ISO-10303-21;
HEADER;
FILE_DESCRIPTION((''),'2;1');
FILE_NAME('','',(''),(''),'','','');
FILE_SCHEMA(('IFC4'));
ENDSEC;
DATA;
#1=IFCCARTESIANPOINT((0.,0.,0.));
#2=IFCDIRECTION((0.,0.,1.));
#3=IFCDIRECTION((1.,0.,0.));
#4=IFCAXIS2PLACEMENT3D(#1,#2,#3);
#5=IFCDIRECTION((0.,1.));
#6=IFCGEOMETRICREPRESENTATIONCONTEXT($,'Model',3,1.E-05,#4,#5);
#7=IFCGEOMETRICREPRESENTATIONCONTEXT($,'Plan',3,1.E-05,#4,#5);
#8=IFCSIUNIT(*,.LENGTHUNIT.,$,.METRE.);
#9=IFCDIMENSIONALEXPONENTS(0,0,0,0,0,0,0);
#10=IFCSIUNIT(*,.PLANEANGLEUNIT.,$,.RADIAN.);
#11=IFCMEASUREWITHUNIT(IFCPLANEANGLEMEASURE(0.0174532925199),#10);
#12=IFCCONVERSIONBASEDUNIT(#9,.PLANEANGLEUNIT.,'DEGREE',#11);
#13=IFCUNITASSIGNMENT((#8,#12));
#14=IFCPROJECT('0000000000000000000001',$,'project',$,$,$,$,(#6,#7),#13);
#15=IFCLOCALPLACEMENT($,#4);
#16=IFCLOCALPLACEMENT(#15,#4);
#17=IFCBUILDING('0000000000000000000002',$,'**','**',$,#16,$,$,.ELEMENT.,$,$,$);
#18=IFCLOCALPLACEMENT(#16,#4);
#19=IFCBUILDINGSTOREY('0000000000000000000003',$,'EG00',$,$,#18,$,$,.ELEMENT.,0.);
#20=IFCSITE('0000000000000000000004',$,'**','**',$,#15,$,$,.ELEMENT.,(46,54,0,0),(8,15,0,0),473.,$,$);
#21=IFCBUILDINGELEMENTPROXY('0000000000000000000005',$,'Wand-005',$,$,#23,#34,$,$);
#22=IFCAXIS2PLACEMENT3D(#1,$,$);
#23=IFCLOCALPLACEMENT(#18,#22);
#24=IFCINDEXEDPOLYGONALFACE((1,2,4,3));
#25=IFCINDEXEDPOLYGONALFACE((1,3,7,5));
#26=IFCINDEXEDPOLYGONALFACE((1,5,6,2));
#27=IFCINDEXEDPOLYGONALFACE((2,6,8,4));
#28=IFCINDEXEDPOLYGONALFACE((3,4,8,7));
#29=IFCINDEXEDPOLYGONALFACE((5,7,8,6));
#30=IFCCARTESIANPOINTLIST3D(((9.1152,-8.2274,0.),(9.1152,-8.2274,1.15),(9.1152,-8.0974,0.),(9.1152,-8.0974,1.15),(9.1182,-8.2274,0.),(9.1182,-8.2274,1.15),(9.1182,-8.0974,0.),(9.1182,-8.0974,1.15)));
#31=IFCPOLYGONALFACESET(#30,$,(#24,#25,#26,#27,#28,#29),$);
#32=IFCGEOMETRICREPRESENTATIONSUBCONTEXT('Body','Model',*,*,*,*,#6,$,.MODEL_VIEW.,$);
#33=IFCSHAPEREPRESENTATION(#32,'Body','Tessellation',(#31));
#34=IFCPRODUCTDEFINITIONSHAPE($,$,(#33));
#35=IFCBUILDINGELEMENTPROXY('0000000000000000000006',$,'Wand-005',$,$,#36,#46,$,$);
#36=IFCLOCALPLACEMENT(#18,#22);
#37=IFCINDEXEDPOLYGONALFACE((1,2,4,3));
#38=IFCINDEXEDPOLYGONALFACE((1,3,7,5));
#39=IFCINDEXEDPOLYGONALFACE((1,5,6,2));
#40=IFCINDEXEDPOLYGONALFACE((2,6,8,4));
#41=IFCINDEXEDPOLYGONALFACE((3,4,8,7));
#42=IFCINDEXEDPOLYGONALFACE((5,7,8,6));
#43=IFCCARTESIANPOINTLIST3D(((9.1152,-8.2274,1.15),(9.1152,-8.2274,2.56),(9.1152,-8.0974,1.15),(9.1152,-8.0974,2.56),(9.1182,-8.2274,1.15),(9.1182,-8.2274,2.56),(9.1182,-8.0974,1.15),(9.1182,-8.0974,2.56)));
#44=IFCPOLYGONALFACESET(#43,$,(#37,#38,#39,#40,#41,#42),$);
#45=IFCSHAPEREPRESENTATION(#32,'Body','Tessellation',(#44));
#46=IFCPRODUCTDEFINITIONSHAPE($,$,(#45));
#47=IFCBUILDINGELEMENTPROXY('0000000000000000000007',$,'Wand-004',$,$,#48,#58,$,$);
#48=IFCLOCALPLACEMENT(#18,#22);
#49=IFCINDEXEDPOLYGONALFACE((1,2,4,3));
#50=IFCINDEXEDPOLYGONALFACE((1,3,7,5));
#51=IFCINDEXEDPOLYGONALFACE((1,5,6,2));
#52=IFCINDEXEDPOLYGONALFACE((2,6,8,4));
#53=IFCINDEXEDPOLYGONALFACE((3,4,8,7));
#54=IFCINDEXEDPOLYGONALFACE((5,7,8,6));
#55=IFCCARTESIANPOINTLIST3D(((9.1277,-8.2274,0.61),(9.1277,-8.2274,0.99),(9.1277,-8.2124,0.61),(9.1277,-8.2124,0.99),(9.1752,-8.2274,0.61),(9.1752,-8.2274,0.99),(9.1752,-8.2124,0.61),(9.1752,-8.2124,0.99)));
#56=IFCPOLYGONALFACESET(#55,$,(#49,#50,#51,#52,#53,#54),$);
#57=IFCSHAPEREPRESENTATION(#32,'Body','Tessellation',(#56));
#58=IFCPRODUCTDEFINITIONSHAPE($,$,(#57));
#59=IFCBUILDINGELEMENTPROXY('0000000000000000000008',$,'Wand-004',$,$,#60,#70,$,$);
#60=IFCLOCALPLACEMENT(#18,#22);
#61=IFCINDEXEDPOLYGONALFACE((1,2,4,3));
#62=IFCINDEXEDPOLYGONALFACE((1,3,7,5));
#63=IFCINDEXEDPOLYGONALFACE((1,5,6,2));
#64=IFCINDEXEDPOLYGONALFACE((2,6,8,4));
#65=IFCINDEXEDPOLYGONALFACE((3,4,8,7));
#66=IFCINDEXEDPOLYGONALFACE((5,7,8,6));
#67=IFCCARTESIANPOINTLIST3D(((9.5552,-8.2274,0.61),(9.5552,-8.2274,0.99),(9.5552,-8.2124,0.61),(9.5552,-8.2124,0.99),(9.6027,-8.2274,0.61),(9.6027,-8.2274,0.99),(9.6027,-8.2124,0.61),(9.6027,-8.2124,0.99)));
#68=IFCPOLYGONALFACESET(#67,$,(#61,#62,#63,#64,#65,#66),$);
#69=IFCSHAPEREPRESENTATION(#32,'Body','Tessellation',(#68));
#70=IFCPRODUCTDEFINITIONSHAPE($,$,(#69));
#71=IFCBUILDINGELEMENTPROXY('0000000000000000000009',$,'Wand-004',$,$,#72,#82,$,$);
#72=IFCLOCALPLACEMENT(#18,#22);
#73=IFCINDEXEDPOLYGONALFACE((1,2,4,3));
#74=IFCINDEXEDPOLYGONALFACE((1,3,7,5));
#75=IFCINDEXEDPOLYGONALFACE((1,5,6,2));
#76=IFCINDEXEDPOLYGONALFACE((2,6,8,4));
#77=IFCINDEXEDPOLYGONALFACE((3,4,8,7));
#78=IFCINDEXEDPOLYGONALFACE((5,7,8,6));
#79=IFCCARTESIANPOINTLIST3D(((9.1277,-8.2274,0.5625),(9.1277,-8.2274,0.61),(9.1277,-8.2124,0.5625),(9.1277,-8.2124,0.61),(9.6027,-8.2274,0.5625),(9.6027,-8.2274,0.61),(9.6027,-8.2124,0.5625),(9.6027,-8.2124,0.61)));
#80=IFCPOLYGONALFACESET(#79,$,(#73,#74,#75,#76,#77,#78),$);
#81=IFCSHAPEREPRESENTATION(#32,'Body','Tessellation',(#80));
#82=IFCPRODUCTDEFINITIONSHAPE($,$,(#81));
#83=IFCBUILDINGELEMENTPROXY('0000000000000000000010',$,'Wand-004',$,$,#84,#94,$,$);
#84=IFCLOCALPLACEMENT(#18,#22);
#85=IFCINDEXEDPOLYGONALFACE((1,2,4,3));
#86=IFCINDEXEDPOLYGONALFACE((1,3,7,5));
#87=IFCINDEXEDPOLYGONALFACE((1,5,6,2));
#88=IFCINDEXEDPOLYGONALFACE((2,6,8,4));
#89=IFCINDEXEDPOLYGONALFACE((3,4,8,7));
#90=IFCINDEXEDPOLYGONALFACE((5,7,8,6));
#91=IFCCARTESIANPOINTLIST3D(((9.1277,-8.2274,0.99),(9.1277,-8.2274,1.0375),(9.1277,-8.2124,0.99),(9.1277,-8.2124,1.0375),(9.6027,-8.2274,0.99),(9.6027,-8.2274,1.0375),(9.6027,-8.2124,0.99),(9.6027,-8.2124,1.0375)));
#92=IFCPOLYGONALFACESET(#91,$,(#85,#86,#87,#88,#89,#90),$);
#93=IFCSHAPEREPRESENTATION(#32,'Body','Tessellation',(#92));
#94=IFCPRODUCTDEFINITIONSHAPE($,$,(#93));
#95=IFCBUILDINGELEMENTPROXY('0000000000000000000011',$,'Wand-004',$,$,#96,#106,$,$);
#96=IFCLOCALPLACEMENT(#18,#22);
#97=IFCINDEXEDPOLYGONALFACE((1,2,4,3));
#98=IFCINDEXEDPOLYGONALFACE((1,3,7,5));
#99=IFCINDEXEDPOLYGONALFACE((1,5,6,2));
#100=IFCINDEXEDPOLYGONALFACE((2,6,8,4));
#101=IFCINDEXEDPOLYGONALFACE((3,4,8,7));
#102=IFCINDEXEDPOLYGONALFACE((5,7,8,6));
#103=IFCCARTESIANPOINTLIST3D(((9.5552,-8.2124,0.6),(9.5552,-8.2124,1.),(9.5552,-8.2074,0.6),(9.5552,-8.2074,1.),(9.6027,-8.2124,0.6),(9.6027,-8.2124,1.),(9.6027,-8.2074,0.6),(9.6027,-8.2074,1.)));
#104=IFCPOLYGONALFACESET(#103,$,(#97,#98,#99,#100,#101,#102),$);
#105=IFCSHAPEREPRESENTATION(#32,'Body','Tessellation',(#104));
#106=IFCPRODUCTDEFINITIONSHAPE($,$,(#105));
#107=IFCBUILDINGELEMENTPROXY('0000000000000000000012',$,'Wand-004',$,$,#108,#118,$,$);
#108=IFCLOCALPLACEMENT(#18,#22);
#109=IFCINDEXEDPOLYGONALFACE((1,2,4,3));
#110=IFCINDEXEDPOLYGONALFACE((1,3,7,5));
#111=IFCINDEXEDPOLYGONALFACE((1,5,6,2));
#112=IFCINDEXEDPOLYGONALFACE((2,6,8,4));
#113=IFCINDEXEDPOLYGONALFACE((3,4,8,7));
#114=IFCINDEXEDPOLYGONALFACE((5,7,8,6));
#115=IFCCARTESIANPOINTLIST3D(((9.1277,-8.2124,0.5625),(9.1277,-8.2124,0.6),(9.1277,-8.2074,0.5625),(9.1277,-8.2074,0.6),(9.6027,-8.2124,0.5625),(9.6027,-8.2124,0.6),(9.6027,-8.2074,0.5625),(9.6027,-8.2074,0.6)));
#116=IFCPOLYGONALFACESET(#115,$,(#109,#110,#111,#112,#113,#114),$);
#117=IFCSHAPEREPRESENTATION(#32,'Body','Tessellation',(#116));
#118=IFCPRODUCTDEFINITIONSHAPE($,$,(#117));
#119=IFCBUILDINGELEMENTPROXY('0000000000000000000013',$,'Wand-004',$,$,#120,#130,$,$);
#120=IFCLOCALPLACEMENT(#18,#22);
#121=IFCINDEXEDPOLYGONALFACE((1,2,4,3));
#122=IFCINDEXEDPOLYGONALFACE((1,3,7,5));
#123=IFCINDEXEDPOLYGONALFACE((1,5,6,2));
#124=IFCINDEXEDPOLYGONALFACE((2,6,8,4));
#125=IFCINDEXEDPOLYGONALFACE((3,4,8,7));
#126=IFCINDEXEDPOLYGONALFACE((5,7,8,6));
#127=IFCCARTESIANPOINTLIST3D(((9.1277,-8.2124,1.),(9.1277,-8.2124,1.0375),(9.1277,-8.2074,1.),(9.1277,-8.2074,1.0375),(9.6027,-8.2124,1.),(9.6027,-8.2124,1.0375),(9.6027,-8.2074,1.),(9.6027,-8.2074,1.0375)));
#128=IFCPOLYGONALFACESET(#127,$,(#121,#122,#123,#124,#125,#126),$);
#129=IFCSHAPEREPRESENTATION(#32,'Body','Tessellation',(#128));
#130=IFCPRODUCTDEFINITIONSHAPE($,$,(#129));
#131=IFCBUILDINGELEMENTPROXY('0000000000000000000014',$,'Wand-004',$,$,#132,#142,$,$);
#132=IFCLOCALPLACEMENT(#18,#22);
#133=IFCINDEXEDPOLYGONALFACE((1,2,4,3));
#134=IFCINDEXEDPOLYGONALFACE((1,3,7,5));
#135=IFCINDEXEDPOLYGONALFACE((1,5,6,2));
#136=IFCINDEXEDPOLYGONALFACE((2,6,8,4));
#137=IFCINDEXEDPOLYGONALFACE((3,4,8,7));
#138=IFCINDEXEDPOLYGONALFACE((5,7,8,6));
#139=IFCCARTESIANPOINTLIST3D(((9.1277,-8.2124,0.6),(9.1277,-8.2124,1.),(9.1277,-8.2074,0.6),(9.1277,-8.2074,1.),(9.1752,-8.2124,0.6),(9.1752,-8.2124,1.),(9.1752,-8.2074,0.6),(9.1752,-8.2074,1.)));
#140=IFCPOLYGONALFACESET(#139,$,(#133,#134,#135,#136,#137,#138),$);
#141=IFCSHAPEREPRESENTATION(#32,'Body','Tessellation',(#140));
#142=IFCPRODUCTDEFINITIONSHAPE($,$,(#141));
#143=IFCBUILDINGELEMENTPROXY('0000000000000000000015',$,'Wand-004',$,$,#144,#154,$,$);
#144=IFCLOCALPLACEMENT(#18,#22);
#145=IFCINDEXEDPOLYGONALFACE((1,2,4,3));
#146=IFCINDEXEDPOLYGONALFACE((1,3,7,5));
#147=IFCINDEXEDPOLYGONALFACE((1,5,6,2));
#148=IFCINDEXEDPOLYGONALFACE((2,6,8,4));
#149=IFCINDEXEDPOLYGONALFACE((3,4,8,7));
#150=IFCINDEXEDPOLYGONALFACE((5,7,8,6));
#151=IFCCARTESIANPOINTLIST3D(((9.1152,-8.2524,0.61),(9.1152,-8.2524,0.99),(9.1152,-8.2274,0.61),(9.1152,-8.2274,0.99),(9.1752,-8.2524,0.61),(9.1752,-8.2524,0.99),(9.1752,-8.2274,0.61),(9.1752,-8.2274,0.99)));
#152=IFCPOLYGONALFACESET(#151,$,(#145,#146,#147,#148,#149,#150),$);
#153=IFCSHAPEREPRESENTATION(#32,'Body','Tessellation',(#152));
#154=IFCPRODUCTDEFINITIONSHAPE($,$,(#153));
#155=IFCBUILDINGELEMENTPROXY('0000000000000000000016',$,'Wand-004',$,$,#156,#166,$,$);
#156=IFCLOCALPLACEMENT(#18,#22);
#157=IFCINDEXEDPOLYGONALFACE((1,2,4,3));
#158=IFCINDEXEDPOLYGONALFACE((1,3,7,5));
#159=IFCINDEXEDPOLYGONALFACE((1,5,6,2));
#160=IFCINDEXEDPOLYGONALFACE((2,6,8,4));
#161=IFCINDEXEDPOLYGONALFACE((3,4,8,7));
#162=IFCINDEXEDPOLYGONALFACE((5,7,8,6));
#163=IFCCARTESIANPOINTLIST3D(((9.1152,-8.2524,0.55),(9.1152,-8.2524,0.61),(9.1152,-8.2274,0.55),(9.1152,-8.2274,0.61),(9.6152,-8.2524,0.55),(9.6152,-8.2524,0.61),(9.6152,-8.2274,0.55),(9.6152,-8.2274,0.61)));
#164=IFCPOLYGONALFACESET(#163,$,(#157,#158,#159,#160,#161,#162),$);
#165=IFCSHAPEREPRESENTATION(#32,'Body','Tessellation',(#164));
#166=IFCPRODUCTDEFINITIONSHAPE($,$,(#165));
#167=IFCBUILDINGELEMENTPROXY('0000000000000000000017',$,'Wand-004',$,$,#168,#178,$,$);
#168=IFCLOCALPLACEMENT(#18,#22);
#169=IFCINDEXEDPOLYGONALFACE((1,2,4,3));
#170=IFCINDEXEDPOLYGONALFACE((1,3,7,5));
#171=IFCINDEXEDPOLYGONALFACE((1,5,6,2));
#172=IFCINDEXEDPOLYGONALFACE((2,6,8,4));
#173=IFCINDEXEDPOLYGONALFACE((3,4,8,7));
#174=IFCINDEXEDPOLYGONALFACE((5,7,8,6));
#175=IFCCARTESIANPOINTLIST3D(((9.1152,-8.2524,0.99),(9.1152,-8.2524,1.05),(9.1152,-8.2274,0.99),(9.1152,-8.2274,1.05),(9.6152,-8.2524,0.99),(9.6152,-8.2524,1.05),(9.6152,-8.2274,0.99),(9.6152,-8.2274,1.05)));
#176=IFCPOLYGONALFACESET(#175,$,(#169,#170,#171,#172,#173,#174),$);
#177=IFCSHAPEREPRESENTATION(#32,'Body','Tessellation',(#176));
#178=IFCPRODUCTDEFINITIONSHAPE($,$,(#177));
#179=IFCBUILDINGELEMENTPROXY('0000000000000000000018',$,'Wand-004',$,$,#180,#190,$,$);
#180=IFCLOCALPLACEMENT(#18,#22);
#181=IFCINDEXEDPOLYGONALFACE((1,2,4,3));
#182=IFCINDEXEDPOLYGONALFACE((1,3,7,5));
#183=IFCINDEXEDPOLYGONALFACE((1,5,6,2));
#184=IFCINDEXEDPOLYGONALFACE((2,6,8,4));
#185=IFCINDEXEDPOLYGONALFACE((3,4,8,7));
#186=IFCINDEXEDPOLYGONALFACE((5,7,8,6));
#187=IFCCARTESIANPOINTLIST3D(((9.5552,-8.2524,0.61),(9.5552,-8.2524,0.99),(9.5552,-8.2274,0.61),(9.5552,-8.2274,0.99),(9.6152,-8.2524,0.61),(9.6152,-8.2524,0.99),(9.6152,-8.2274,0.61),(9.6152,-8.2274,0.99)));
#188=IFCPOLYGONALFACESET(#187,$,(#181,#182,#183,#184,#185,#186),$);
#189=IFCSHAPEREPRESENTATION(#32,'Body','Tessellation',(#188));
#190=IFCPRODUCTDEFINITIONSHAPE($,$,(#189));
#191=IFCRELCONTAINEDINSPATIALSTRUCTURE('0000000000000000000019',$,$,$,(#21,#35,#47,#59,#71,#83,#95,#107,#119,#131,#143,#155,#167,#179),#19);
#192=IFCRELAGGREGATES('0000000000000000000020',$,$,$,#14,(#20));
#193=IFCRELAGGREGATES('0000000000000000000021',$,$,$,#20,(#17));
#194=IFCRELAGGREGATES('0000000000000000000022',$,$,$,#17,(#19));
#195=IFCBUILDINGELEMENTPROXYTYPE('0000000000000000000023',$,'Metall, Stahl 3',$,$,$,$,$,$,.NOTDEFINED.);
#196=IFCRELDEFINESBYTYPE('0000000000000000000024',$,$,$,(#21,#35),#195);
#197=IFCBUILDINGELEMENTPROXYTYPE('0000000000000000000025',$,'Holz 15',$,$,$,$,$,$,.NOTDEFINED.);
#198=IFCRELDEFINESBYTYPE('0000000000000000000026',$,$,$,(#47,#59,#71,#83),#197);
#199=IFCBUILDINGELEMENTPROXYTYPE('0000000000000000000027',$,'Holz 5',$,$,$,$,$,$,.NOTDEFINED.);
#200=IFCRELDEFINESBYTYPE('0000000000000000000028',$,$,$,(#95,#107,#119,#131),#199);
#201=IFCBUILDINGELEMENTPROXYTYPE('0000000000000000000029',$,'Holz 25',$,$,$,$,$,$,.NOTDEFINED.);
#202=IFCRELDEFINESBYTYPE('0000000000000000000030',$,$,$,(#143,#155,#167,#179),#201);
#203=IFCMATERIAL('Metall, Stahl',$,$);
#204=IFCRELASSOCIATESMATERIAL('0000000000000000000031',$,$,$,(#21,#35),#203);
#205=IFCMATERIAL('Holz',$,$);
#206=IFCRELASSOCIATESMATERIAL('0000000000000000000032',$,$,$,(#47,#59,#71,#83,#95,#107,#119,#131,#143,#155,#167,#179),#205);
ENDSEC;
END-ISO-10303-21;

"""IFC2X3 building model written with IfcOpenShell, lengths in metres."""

from ifc_helpers import new_model, entity, si_unit, converted_unit, direction, frame, origin_with_axes, place, context, subcontext, project, spatial, polyline, outline, extrude, material, type_object, element, save


model = new_model("IFC2X3")

# Units and contexts
model_context = context("Model", 3, precision=1e-05, world=origin_with_axes(), true_north=direction((0.0, 1.0)))
plan_context = context("Plan", 3, precision=1e-05, world=origin_with_axes(), true_north=direction((0.0, 1.0)))
body_context = subcontext(model_context, "Body", "Model", "MODEL_VIEW")
ifc_project = project(units=[si_unit("LENGTHUNIT", "METRE"), converted_unit("PLANEANGLEUNIT", "DEGREE", entity("IfcPlaneAngleMeasure", 0.0174532925199), si_unit("PLANEANGLEUNIT", "RADIAN"), dimensions=[0, 0, 0, 0, 0, 0, 0])], contexts=[model_context, plan_context])

# Site, building, storey
site_placement = place(None, origin_with_axes())
site = spatial("IfcSite", under=ifc_project, at=site_placement, Name="**", Description="**", CompositionType="ELEMENT", RefLatitude=(46, 54, 0, 0), RefLongitude=(8, 15, 0, 0), RefElevation=473.0)
building_placement = place(site_placement, origin_with_axes())
building = spatial("IfcBuilding", under=site, at=building_placement, Name="**", Description="**", CompositionType="ELEMENT")
storey_placement = place(building_placement, origin_with_axes())
storey = spatial("IfcBuildingStorey", under=building, at=storey_placement, Name="EG00", CompositionType="ELEMENT", Elevation=0.0)

# Building element proxies
ifc_material_1 = material(Name="Metall, Stahl")
building_element_proxy_type_1 = type_object("IfcBuildingElementProxyType", Name="Metall, Stahl 3", PredefinedType="NOTDEFINED")
proxy_1_placement = place(storey_placement, frame((9.1152, -8.0974, 0.0), z_axis=(0.0, 0.0, 1.0), x_axis=(0.0, -1.0, 0.0)))
element("IfcBuildingElementProxy", 1, at=proxy_1_placement, inside=storey, type_object=building_element_proxy_type_1, material=ifc_material_1, Name="Wand-005", context=body_context, shape_type="SweptSolid", body=[
    extrude(outline(polyline([(0.0, 0.0), (0.13, 0.0), (0.13, 0.003), (0.0, 0.003), (0.0, 0.0)])), origin_with_axes(), (0.0, 0.0, 1.0), 1.15),
])
proxy_2_placement = place(storey_placement, frame((9.1152, -8.0974, 1.15), z_axis=(0.0, 0.0, 1.0), x_axis=(0.0, -1.0, 0.0)))
element("IfcBuildingElementProxy", 2, at=proxy_2_placement, inside=storey, type_object=building_element_proxy_type_1, material=ifc_material_1, Name="Wand-005", context=body_context, shape_type="SweptSolid", body=[
    extrude(outline(polyline([(0.0, 0.0), (0.13, 0.0), (0.13, 0.003), (0.0, 0.003), (0.0, 0.0)])), origin_with_axes(), (0.0, 0.0, 1.0), 1.41),
])
ifc_material_2 = material(Name="Holz")
building_element_proxy_type_2 = type_object("IfcBuildingElementProxyType", Name="Holz 15", PredefinedType="NOTDEFINED")
for number, where, z_axis, x_axis, name in (
    (3, (9.1277, -8.2274, 0.61), (0.0, 0.0, 1.0), (1.0, 0.0, 0.0), "Wand-004"),
    (4, (9.5552, -8.2274, 0.61), (0.0, 0.0, 1.0), (1.0, 0.0, 0.0), "Wand-004"),
):
    element("IfcBuildingElementProxy", number, at=place(storey_placement, frame(where, z_axis=z_axis, x_axis=x_axis)), inside=storey, type_object=building_element_proxy_type_2, material=ifc_material_2, Name=name, context=body_context, shape_type="SweptSolid", body=[
        extrude(outline(polyline([(0.0, 0.0), (0.0475, 0.0), (0.0475, 0.015), (0.0, 0.015), (0.0, 0.0)])), origin_with_axes(), (0.0, 0.0, 1.0), 0.38),
    ])
for number, where, z_axis, x_axis, name in (
    (5, (9.6027, -8.2124, 0.5625), (0.0, 0.0, 1.0), (-1.0, 0.0, 0.0), "Wand-004"),
    (6, (9.6027, -8.2124, 0.99), (0.0, 0.0, 1.0), (-1.0, 0.0, 0.0), "Wand-004"),
):
    element("IfcBuildingElementProxy", number, at=place(storey_placement, frame(where, z_axis=z_axis, x_axis=x_axis)), inside=storey, type_object=building_element_proxy_type_2, material=ifc_material_2, Name=name, context=body_context, shape_type="SweptSolid", body=[
        extrude(outline(polyline([(0.0, 0.0), (0.475, 0.0), (0.475, 0.015), (0.0, 0.015), (0.0, 0.0)])), origin_with_axes(), (0.0, 0.0, 1.0), 0.0475),
    ])
building_element_proxy_type_3 = type_object("IfcBuildingElementProxyType", Name="Holz 5", PredefinedType="NOTDEFINED")
proxy_3_placement = place(storey_placement, frame((9.5552, -8.2124, 0.6), z_axis=(0.0, 0.0, 1.0), x_axis=(1.0, 0.0, 0.0)))
element("IfcBuildingElementProxy", 7, at=proxy_3_placement, inside=storey, type_object=building_element_proxy_type_3, material=ifc_material_2, Name="Wand-004", context=body_context, shape_type="SweptSolid", body=[
    extrude(outline(polyline([(0.0, 0.0), (0.0475, 0.0), (0.0475, 0.005), (0.0, 0.005), (0.0, 0.0)])), origin_with_axes(), (0.0, 0.0, 1.0), 0.4),
])
for number, where, z_axis, x_axis, name in (
    (8, (9.6027, -8.2124, 0.5625), (0.0, 0.0, 1.0), (-1.0, 0.0, 0.0), "Wand-004"),
    (9, (9.6027, -8.2124, 1.0), (0.0, 0.0, 1.0), (-1.0, 0.0, 0.0), "Wand-004"),
):
    element("IfcBuildingElementProxy", number, at=place(storey_placement, frame(where, z_axis=z_axis, x_axis=x_axis)), inside=storey, type_object=building_element_proxy_type_3, material=ifc_material_2, Name=name, context=body_context, shape_type="SweptSolid", body=[
        extrude(outline(polyline([(0.0, -0.005), (0.475, -0.005), (0.475, 0.0), (0.0, 0.0), (0.0, -0.005)])), origin_with_axes(), (0.0, 0.0, 1.0), 0.0375),
    ])
proxy_4_placement = place(storey_placement, frame((9.1277, -8.2124, 0.6), z_axis=(0.0, 0.0, 1.0), x_axis=(1.0, 0.0, 0.0)))
element("IfcBuildingElementProxy", 10, at=proxy_4_placement, inside=storey, type_object=building_element_proxy_type_3, material=ifc_material_2, Name="Wand-004", context=body_context, shape_type="SweptSolid", body=[
    extrude(outline(polyline([(0.0, 0.0), (0.0475, 0.0), (0.0475, 0.005), (0.0, 0.005), (0.0, 0.0)])), origin_with_axes(), (0.0, 0.0, 1.0), 0.4),
])
building_element_proxy_type_4 = type_object("IfcBuildingElementProxyType", Name="Holz 25", PredefinedType="NOTDEFINED")
proxy_5_placement = place(storey_placement, frame((9.1152, -8.2524, 0.61), z_axis=(0.0, 0.0, 1.0), x_axis=(1.0, 0.0, 0.0)))
element("IfcBuildingElementProxy", 11, at=proxy_5_placement, inside=storey, type_object=building_element_proxy_type_4, material=ifc_material_2, Name="Wand-004", context=body_context, shape_type="SweptSolid", body=[
    extrude(outline(polyline([(0.0, 0.0), (0.06, 0.0), (0.06, 0.025), (0.0, 0.025), (0.0, 0.0)])), origin_with_axes(), (0.0, 0.0, 1.0), 0.38),
])
for number, where, z_axis, x_axis, name in (
    (12, (9.6152, -8.2274, 0.55), (0.0, 0.0, 1.0), (-1.0, 0.0, 0.0), "Wand-004"),
    (13, (9.6152, -8.2274, 0.99), (0.0, 0.0, 1.0), (-1.0, 0.0, 0.0), "Wand-004"),
):
    element("IfcBuildingElementProxy", number, at=place(storey_placement, frame(where, z_axis=z_axis, x_axis=x_axis)), inside=storey, type_object=building_element_proxy_type_4, material=ifc_material_2, Name=name, context=body_context, shape_type="SweptSolid", body=[
        extrude(outline(polyline([(0.0, 0.0), (0.5, 0.0), (0.5, 0.025), (0.0, 0.025), (0.0, 0.0)])), origin_with_axes(), (0.0, 0.0, 1.0), 0.06),
    ])
proxy_6_placement = place(storey_placement, frame((9.5552, -8.2524, 0.61), z_axis=(0.0, 0.0, 1.0), x_axis=(1.0, 0.0, 0.0)))
element("IfcBuildingElementProxy", 14, at=proxy_6_placement, inside=storey, type_object=building_element_proxy_type_4, material=ifc_material_2, Name="Wand-004", context=body_context, shape_type="SweptSolid", body=[
    extrude(outline(polyline([(0.0, 0.0), (0.06, 0.0), (0.06, 0.025), (0.0, 0.025), (0.0, 0.0)])), origin_with_axes(), (0.0, 0.0, 1.0), 0.38),
])

save(model, "model.ifc")
